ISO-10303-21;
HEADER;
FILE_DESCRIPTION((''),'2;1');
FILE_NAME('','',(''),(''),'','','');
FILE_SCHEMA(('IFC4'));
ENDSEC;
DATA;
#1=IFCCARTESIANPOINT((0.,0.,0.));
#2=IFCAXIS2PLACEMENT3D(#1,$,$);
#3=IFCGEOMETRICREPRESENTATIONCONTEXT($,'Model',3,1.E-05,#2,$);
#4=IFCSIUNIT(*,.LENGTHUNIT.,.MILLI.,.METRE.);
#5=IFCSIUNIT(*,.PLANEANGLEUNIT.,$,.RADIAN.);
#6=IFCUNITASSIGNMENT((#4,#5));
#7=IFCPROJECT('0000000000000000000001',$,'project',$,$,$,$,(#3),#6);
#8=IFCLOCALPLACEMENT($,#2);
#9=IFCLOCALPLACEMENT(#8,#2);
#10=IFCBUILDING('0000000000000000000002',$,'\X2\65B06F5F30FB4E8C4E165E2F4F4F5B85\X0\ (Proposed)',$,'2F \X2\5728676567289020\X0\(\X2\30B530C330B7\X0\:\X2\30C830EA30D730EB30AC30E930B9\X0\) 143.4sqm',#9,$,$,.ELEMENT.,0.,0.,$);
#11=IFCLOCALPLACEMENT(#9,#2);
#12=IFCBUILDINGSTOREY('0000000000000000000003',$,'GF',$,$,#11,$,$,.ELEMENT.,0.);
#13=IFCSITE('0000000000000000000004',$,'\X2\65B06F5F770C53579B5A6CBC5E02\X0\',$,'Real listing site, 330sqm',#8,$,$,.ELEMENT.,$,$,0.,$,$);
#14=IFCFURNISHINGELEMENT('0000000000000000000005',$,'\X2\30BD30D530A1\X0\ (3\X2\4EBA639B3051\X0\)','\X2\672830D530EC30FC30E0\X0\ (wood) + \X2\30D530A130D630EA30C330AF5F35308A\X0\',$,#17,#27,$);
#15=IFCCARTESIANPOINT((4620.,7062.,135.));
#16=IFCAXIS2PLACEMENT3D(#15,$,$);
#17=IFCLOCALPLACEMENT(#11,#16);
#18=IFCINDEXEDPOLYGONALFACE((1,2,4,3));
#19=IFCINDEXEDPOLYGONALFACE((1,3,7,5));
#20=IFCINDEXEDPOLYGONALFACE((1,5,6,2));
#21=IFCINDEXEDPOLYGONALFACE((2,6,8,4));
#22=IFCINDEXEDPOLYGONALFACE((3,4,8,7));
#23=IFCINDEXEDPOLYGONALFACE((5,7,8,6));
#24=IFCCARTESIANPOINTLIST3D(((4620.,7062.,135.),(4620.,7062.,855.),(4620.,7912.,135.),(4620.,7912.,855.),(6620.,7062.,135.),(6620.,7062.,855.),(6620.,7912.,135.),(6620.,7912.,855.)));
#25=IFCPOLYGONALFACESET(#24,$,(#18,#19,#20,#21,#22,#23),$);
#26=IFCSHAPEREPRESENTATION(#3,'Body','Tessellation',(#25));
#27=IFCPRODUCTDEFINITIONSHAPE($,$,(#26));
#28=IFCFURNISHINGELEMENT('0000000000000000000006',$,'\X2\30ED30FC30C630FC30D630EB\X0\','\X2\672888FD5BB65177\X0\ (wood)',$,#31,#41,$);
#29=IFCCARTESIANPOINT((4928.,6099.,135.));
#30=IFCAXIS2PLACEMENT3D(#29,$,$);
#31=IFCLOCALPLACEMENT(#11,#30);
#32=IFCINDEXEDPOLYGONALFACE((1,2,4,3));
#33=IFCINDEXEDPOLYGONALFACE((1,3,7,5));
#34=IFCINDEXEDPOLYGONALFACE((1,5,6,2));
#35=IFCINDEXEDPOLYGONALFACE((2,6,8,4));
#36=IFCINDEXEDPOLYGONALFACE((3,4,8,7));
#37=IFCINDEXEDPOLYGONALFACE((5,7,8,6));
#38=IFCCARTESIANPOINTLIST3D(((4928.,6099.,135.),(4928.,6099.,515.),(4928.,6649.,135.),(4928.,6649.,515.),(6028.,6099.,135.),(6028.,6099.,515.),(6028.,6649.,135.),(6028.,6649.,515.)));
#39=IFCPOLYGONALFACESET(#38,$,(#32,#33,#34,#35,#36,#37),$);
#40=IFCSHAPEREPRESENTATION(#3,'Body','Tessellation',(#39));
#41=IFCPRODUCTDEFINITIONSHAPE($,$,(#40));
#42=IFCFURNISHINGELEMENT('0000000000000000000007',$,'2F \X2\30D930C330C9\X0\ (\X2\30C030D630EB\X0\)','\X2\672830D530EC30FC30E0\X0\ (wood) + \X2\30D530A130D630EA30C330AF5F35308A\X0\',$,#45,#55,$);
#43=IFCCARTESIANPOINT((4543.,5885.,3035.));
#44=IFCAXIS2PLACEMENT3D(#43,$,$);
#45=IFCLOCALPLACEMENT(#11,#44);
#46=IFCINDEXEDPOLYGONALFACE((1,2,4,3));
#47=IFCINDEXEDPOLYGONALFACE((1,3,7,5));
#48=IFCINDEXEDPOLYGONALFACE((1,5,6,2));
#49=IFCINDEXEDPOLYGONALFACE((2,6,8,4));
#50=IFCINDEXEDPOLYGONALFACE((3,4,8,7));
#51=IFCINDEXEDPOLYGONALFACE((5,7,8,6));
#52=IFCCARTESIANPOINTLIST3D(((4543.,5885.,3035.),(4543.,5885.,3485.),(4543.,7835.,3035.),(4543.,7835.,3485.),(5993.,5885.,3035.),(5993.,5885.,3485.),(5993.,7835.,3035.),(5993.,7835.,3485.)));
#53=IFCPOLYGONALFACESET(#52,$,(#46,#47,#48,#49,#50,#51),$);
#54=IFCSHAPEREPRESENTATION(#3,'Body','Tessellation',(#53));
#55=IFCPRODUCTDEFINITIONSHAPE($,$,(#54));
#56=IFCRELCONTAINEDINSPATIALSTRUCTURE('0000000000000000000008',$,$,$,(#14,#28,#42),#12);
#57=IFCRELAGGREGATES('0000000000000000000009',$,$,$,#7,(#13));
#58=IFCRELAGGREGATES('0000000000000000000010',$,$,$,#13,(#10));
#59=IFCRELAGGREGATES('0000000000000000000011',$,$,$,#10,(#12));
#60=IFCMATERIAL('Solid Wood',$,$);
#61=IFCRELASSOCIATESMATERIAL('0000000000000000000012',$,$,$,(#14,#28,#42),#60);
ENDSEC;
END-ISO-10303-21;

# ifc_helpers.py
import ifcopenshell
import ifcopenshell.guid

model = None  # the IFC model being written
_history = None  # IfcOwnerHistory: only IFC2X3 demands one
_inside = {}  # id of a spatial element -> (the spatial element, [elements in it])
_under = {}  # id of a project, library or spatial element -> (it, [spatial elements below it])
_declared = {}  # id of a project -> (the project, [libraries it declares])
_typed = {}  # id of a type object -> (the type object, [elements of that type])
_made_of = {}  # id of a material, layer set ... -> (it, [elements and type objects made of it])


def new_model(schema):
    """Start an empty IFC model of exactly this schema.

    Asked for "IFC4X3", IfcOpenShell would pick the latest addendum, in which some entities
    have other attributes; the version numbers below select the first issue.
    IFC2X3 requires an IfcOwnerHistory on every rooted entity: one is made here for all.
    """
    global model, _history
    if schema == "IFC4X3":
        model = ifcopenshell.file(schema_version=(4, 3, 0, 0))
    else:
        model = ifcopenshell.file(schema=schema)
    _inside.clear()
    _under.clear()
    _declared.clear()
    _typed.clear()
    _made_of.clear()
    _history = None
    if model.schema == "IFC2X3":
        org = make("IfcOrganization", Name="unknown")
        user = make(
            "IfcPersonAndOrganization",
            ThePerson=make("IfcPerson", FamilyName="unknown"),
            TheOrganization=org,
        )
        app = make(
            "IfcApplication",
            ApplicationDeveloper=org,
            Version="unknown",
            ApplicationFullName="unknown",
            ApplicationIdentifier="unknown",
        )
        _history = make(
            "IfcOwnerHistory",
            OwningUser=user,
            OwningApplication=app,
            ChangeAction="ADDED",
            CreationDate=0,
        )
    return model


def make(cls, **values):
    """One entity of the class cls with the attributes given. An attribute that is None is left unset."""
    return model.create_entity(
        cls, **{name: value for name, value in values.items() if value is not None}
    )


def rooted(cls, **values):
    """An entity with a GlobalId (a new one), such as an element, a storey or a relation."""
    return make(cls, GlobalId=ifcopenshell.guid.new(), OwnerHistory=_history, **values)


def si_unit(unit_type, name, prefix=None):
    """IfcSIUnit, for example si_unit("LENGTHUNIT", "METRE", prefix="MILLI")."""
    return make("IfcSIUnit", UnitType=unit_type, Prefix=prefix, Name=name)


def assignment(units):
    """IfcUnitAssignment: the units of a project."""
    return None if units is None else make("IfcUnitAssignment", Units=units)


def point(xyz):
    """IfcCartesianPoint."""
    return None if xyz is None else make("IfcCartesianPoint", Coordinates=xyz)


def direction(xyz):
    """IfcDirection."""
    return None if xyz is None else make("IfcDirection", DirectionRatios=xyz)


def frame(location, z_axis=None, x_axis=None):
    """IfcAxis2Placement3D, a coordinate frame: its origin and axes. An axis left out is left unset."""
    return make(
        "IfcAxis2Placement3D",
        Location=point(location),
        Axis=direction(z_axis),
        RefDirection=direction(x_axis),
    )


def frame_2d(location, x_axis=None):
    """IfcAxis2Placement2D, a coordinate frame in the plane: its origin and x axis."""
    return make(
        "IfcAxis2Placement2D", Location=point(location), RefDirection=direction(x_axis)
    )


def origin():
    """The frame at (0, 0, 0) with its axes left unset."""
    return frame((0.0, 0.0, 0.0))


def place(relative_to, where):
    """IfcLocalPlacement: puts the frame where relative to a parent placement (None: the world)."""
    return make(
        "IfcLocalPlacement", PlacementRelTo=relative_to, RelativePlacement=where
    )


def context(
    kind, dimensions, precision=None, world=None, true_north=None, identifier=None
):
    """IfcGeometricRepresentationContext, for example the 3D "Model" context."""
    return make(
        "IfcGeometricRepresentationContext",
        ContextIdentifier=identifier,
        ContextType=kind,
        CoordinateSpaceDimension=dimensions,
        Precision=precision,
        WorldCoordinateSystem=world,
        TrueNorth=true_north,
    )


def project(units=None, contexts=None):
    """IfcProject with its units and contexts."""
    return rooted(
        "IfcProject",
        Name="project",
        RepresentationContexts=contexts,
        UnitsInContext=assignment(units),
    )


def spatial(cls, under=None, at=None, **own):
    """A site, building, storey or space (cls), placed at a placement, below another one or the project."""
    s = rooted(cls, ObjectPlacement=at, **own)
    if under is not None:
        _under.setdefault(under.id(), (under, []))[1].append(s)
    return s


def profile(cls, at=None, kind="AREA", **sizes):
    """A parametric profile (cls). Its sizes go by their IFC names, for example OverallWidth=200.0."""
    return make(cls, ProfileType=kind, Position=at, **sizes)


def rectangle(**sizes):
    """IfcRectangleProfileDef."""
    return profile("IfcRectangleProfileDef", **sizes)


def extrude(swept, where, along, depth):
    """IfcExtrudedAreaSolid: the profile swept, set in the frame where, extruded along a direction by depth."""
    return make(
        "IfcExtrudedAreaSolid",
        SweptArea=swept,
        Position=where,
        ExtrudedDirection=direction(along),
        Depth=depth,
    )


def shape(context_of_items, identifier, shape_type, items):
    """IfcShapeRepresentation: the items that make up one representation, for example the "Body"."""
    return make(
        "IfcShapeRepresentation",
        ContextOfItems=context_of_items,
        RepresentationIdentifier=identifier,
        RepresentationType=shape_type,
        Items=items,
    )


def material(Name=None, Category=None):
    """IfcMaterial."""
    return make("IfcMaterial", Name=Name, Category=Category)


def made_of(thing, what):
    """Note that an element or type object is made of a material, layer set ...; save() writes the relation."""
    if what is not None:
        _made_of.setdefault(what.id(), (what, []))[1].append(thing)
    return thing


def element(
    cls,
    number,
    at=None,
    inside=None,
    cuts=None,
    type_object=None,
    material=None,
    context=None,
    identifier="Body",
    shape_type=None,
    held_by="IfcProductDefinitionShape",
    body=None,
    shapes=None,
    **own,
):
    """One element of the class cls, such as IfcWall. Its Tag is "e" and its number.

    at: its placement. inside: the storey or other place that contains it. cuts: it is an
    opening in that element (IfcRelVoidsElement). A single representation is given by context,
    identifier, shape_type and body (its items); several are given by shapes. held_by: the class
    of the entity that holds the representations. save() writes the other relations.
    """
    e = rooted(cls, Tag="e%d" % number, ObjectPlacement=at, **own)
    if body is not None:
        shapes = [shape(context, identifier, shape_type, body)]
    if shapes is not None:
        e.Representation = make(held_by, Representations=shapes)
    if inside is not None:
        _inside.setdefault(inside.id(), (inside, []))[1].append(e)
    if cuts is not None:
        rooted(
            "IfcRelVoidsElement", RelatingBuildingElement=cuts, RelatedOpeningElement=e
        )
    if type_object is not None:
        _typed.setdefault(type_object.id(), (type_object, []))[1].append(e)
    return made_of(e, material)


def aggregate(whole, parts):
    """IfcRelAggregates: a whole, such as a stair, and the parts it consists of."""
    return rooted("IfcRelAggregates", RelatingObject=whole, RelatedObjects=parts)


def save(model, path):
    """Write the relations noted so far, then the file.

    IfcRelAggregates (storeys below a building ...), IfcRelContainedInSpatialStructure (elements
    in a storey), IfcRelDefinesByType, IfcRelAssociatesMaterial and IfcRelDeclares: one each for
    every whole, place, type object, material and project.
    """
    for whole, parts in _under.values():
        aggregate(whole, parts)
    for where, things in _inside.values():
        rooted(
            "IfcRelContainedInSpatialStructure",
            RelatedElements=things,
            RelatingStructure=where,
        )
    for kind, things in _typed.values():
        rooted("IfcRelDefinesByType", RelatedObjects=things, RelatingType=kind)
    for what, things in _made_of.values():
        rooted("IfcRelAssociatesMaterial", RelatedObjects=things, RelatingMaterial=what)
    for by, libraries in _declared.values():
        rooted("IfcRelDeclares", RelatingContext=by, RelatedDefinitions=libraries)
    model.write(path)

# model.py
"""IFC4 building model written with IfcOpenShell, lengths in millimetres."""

from ifc_helpers import new_model, si_unit, frame, frame_2d, origin, place, context, project, spatial, rectangle, extrude, material, element, save


model = new_model("IFC4")

# Units and contexts
model_context = context("Model", 3, precision=1e-05, world=origin())
ifc_project = project(units=[si_unit("LENGTHUNIT", "METRE", prefix="MILLI"), si_unit("PLANEANGLEUNIT", "RADIAN")], contexts=[model_context])

# Site, building, storey
site_placement = place(None, origin())
site = spatial("IfcSite", under=ifc_project, at=site_placement, Name="新潟県南魚沼市", ObjectType="Real listing site, 330sqm", CompositionType="ELEMENT", RefElevation=0.0)
building_placement = place(site_placement, origin())
building = spatial("IfcBuilding", under=site, at=building_placement, Name="新潟・二世帯住宅 (Proposed)", ObjectType="2F 在来木造(サッシ:トリプルガラス) 143.4sqm", CompositionType="ELEMENT", ElevationOfRefHeight=0.0, ElevationOfTerrain=0.0)
storey_placement = place(building_placement, origin())
storey = spatial("IfcBuildingStorey", under=building, at=storey_placement, Name="GF", CompositionType="ELEMENT", Elevation=0.0)

# Shared definitions
ifc_material_1 = material(Name="Solid Wood")

# Furnishing elements
furnishing_1_placement = place(storey_placement, frame((4620.0, 7062.0, 135.0)))
element("IfcFurnishingElement", 1, at=furnishing_1_placement, inside=storey, material=ifc_material_1, Name="ソファ (3人掛け)", Description="木フレーム (wood) + ファブリック張り", context=model_context, shape_type="SweptSolid", body=[
    extrude(rectangle(XDim=2000.0, YDim=850.0, at=frame_2d((1000.0, 425.0))), frame((4620.0, 7062.0, 135.0)), (0.0, 0.0, 1.0), 720.0),
])
furnishing_2_placement = place(storey_placement, frame((4928.0, 6099.0, 135.0)))
element("IfcFurnishingElement", 2, at=furnishing_2_placement, inside=storey, material=ifc_material_1, Name="ローテーブル", Description="木製家具 (wood)", context=model_context, shape_type="SweptSolid", body=[
    extrude(rectangle(XDim=1100.0, YDim=550.0, at=frame_2d((550.0, 275.0))), frame((4928.0, 6099.0, 135.0)), (0.0, 0.0, 1.0), 380.0),
])
furnishing_3_placement = place(storey_placement, frame((4543.0, 5885.0, 3035.0)))
element("IfcFurnishingElement", 3, at=furnishing_3_placement, inside=storey, material=ifc_material_1, Name="2F ベッド (ダブル)", Description="木フレーム (wood) + ファブリック張り", context=model_context, shape_type="SweptSolid", body=[
    extrude(rectangle(XDim=1450.0, YDim=1950.0, at=frame_2d((725.0, 975.0))), frame((4543.0, 5885.0, 3035.0)), (0.0, 0.0, 1.0), 450.0),
])

save(model, "model.ifc")
